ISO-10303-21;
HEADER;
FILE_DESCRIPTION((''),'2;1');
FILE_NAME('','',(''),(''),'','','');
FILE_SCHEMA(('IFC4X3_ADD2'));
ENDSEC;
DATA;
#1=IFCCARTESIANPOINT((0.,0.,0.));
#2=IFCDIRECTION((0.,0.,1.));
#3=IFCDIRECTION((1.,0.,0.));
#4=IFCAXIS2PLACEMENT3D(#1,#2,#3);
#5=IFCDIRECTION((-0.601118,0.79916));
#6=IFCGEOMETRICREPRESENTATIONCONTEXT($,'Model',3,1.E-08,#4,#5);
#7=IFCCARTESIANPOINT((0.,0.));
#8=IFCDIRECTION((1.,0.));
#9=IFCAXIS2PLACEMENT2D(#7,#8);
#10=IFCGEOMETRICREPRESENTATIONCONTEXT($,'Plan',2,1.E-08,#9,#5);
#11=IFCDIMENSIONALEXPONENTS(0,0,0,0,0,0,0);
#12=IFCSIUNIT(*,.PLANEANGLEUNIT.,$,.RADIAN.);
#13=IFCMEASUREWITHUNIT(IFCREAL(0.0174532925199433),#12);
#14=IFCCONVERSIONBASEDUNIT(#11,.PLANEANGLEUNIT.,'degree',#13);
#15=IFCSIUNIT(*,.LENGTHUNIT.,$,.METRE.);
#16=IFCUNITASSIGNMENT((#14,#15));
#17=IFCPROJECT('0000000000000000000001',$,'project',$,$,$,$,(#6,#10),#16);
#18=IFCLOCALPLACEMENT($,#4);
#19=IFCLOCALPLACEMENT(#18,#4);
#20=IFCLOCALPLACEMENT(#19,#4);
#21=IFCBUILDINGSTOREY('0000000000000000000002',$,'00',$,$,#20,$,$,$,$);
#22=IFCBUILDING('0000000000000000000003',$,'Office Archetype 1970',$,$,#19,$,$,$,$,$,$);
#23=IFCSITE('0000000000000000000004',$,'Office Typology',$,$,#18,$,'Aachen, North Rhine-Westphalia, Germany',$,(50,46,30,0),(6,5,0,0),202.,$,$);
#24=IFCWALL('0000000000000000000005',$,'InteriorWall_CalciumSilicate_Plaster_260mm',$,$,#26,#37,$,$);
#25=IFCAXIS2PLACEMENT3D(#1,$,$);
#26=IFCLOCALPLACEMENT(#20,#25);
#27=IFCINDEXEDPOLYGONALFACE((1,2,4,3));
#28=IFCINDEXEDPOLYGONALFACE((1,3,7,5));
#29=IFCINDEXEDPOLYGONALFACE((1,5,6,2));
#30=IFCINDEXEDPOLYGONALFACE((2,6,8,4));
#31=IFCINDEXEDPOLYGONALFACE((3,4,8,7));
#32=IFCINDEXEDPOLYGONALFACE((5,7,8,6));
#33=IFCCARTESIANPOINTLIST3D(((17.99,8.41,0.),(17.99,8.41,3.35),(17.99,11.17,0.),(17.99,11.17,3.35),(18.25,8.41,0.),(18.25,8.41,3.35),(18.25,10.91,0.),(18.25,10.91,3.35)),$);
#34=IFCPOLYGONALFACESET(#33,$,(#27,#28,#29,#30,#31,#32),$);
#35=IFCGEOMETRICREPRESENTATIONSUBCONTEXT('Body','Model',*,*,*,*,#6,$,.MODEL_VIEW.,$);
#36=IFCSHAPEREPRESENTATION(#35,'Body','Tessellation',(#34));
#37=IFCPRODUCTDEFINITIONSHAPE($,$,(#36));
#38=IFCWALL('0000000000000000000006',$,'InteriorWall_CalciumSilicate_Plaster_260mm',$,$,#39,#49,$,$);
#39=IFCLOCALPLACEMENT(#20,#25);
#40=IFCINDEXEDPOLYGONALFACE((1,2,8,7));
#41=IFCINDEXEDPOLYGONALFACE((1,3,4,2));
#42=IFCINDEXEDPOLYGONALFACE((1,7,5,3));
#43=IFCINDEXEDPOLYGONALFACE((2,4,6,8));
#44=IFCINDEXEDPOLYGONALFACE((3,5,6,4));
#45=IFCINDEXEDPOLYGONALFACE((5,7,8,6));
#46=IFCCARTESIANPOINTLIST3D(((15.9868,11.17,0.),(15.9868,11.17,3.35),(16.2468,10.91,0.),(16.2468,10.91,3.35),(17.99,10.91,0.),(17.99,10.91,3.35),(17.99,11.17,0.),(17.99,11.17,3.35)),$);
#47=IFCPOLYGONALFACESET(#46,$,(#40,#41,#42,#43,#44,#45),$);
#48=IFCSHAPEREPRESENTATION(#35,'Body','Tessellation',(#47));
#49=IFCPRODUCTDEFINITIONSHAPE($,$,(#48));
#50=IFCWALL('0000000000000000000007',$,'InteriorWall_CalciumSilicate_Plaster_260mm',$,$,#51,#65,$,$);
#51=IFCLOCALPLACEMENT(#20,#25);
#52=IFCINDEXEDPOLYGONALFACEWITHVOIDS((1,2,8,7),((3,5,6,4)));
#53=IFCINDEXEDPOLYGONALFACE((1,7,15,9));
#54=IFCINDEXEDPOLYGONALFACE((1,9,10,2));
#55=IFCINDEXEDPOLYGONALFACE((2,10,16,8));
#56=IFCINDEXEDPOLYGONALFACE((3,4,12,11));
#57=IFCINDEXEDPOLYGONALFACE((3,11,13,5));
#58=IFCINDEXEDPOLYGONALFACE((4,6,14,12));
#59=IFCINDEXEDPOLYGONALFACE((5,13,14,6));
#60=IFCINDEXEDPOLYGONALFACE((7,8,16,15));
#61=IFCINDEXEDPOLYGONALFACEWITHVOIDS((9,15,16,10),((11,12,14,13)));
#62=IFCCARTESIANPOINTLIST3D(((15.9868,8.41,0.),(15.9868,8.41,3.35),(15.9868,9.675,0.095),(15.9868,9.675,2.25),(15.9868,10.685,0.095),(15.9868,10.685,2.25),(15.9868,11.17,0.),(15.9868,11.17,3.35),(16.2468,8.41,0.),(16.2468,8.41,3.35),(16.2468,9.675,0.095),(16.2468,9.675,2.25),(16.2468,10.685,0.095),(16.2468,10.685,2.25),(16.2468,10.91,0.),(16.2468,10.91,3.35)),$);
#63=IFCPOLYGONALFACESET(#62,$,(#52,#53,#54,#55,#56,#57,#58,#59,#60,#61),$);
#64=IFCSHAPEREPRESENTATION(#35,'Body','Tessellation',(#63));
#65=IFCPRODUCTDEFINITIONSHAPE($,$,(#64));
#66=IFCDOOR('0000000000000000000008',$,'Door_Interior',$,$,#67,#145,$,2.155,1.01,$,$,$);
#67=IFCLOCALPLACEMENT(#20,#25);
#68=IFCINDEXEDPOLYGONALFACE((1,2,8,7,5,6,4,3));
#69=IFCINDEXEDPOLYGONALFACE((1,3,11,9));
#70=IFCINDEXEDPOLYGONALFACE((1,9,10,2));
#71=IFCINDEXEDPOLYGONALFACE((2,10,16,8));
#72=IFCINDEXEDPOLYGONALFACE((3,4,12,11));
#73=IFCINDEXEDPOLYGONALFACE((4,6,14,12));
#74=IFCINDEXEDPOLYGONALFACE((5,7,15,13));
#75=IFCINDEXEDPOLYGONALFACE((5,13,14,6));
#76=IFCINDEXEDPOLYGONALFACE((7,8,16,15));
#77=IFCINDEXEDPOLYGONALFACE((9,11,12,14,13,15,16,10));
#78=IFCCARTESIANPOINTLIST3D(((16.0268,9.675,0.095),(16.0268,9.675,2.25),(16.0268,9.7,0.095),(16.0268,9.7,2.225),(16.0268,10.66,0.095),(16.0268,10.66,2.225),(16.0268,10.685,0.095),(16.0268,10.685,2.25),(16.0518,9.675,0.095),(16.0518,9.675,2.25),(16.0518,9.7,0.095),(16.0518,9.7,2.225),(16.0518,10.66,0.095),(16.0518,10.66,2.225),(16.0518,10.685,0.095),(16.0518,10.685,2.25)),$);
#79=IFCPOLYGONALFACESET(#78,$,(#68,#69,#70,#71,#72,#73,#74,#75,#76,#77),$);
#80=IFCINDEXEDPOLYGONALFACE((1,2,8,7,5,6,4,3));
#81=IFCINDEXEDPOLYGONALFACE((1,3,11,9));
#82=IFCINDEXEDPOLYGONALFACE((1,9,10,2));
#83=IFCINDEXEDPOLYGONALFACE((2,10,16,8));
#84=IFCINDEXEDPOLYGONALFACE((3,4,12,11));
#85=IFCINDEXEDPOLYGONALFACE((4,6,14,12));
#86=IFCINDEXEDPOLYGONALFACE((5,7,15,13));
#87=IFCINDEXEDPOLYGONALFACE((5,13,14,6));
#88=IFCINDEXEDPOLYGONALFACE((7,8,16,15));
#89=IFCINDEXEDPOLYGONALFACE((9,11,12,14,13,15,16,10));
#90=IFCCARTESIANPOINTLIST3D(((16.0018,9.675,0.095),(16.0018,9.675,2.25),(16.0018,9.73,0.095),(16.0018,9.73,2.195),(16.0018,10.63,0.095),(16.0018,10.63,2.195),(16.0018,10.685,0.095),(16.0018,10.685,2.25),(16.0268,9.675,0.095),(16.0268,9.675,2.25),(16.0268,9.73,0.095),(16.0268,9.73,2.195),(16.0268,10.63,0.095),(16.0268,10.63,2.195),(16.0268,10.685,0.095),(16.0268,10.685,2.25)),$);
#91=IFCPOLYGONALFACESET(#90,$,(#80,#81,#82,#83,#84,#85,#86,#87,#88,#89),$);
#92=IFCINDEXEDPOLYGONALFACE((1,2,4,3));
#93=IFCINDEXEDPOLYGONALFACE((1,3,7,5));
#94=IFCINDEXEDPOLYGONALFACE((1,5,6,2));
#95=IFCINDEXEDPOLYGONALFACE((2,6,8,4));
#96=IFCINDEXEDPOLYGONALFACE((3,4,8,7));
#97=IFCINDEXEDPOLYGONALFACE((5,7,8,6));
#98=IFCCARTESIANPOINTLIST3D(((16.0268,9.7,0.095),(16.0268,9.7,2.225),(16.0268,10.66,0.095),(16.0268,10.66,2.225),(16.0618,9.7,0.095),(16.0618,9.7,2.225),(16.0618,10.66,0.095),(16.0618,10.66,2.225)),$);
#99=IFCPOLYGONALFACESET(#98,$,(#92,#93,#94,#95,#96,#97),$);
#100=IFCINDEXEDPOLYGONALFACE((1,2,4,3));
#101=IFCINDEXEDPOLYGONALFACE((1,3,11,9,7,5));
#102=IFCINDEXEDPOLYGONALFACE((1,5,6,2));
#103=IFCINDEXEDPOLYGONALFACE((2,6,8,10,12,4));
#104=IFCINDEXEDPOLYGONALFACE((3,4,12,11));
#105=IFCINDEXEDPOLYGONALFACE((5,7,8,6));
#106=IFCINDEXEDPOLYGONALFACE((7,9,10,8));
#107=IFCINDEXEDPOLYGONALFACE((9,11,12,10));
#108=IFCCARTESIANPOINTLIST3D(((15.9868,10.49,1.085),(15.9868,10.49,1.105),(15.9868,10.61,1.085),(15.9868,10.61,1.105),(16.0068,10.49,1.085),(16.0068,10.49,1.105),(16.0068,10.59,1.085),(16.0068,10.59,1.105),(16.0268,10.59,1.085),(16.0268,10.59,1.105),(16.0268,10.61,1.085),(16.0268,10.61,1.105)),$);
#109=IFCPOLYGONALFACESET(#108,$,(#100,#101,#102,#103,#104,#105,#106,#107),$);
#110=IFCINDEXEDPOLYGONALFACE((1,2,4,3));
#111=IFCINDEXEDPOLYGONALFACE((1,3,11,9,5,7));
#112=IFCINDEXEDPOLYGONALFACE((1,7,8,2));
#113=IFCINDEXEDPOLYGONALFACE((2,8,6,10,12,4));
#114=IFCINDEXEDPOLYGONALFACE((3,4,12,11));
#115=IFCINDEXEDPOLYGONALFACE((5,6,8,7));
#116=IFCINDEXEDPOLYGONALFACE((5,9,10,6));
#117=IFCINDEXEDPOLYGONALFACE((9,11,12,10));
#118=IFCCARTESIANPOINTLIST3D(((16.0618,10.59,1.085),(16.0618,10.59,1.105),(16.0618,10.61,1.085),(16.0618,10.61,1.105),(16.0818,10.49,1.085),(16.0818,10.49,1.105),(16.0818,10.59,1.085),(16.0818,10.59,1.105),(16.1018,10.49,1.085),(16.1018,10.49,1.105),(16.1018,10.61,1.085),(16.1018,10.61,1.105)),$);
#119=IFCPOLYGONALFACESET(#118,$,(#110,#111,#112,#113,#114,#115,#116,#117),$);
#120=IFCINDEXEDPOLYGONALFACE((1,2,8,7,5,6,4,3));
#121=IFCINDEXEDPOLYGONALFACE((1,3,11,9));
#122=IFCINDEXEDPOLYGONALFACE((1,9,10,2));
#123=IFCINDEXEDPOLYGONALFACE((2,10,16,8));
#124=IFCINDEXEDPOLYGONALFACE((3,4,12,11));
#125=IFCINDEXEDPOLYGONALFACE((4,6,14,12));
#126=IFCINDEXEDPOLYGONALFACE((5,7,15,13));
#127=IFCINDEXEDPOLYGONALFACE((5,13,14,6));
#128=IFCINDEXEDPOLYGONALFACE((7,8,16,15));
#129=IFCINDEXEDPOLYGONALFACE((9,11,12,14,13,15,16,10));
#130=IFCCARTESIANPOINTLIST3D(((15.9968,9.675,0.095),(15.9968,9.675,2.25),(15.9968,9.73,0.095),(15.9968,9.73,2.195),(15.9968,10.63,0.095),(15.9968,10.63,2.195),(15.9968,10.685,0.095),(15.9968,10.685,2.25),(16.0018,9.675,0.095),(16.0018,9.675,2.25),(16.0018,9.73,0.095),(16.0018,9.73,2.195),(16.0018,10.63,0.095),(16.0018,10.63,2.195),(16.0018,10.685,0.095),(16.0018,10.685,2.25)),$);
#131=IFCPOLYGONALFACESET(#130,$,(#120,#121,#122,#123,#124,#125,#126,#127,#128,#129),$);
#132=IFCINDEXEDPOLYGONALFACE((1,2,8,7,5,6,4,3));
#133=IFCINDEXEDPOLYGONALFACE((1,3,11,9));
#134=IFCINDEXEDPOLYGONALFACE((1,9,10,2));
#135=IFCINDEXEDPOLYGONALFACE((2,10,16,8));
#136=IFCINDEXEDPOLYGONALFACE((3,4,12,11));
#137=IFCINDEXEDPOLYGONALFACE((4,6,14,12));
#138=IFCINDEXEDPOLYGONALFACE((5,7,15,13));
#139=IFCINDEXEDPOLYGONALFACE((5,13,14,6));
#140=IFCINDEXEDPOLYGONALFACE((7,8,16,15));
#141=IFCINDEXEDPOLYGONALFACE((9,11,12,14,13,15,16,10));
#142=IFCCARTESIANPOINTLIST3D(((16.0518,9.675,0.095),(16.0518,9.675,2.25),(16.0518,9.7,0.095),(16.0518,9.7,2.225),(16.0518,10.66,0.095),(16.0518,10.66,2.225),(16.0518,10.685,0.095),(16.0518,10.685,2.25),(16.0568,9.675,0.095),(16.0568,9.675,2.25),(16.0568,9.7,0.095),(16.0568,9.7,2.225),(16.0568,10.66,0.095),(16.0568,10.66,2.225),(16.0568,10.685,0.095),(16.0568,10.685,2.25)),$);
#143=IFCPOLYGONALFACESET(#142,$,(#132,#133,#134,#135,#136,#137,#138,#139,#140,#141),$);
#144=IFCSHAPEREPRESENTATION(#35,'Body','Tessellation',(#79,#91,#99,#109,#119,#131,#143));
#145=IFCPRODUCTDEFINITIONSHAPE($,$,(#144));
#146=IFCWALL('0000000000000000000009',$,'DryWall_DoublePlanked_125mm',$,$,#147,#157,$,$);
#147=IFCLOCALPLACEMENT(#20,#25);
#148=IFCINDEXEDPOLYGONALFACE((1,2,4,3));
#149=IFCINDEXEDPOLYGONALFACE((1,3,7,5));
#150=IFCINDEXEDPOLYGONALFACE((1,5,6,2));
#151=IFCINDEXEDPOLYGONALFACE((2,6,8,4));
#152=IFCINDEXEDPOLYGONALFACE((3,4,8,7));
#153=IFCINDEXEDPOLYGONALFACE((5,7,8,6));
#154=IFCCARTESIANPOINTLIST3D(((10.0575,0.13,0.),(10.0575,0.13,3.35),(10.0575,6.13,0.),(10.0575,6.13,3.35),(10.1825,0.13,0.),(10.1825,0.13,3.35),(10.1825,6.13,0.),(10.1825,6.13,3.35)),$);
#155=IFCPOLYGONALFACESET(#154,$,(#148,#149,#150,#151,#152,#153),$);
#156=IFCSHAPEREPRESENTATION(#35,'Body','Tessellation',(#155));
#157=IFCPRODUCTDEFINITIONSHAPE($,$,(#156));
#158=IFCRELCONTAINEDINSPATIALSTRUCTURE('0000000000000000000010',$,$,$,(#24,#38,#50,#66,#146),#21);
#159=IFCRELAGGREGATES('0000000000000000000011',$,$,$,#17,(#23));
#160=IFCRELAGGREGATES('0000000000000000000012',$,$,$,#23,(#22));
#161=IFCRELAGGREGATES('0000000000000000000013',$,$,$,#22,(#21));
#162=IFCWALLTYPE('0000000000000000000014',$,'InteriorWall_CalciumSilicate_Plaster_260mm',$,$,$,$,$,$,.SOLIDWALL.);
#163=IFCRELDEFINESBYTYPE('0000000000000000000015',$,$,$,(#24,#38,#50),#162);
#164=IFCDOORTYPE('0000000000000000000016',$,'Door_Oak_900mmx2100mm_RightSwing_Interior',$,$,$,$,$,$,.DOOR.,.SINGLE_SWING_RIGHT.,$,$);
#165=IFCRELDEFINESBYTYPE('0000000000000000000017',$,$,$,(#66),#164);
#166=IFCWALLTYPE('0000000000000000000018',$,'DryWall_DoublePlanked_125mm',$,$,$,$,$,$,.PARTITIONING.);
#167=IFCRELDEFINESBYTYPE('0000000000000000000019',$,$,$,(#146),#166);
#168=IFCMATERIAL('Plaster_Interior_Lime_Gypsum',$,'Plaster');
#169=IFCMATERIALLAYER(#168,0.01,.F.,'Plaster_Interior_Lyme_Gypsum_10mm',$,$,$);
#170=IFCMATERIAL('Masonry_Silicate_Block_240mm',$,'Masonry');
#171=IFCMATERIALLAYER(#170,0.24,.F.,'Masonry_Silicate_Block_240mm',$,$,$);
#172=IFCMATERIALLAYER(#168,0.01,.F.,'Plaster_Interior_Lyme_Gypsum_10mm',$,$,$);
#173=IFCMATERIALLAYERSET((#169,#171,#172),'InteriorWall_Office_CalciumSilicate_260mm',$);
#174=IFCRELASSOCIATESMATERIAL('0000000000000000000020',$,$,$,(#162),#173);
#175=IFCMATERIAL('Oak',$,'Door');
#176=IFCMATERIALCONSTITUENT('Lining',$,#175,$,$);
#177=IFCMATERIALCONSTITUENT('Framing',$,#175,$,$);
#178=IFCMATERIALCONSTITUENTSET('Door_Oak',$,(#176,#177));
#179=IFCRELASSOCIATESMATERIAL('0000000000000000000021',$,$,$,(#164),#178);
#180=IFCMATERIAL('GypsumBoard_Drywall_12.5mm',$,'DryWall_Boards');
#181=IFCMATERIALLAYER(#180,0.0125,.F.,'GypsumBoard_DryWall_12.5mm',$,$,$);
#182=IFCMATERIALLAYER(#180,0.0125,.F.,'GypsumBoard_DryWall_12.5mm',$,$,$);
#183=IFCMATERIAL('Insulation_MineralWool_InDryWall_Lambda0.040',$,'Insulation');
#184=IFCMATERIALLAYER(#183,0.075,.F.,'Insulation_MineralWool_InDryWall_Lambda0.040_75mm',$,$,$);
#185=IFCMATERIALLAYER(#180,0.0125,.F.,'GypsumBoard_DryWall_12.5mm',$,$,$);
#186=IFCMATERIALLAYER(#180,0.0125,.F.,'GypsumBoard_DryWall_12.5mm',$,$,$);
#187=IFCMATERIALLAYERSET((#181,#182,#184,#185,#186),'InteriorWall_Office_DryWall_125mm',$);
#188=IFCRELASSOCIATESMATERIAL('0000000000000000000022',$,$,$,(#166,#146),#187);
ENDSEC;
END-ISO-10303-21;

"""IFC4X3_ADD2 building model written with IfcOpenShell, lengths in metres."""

from ifc_helpers import new_model, entity, si_unit, converted_unit, direction, frame, origin_with_axes, origin_2d_with_axis, place, context, subcontext, project, spatial, line, indexed_curve, outline, extrude, source, transform, mapped, material, layer, layer_set, layer_usage, constituent, constituent_set, type_object, type_shapes, element, fill, save


model = new_model("IFC4X3_ADD2")

# Units and contexts
model_context = context("Model", 3, precision=1e-08, world=origin_with_axes(), true_north=direction((-0.601118, 0.79916)))
plan_context = context("Plan", 2, precision=1e-08, world=origin_2d_with_axis(), true_north=direction((-0.601118, 0.79916)))
body_context = subcontext(model_context, "Body", "Model", "MODEL_VIEW")
ifc_project = project(units=[converted_unit("PLANEANGLEUNIT", "degree", entity("IfcReal", 0.0174532925199433), si_unit("PLANEANGLEUNIT", "RADIAN"), dimensions=[0, 0, 0, 0, 0, 0, 0]), si_unit("LENGTHUNIT", "METRE")], contexts=[model_context, plan_context])

# Site, building, storey
site_placement = place(None, origin_with_axes())
site = spatial("IfcSite", under=ifc_project, at=site_placement, Name="Office Typology", LongName="Aachen, North Rhine-Westphalia, Germany", RefLatitude=(50, 46, 30, 0), RefLongitude=(6, 5, 0, 0), RefElevation=202.0)
building_placement = place(site_placement, origin_with_axes())
building = spatial("IfcBuilding", under=site, at=building_placement, Name="Office Archetype 1970")
storey_placement = place(building_placement, origin_with_axes())
storey = spatial("IfcBuildingStorey", under=building, at=storey_placement, Name="00")

# Walls
ifc_material_1 = material(Name="Plaster_Interior_Lime_Gypsum", Category="Plaster")
ifc_layer_1 = layer(ifc_material_1, 0.01, ventilated=False, Name="Plaster_Interior_Lyme_Gypsum_10mm")
ifc_material_2 = material(Name="Masonry_Silicate_Block_240mm", Category="Masonry")
ifc_layer_2 = layer(ifc_material_2, 0.24, ventilated=False, Name="Masonry_Silicate_Block_240mm")
ifc_layer_3 = layer(ifc_material_1, 0.01, ventilated=False, Name="Plaster_Interior_Lyme_Gypsum_10mm")
ifc_layer_set_1 = layer_set([ifc_layer_1, ifc_layer_2, ifc_layer_3], Name="InteriorWall_Office_CalciumSilicate_260mm")
wall_type_1 = type_object("IfcWallType", Name="InteriorWall_CalciumSilicate_Plaster_260mm", PredefinedType="SOLIDWALL", material=ifc_layer_set_1)
wall_1_placement = place(storey_placement, frame((17.99, 11.17, 0.0), z_axis=(0.0, 0.0, 1.0), x_axis=(0.0, -1.0, 0.0)))
element("IfcWall", 1, at=wall_1_placement, inside=storey, type_object=wall_type_1, Name="InteriorWall_CalciumSilicate_Plaster_260mm", context=body_context, shape_type="SweptSolid", body=[
    extrude(outline(indexed_curve([(0.0, 0.0), (0.26, 0.26), (2.76, 0.26), (2.76, 0.0)], segments=[line(1, 2, 3, 4, 1)])), origin_with_axes(), (0.0, 0.0, 1.0), 3.35),
])
wall_2_placement = place(storey_placement, frame((17.99, 11.17, 0.0), z_axis=(0.0, 0.0, 1.0), x_axis=(-1.0, 0.0, 0.0)))
element("IfcWall", 2, at=wall_2_placement, inside=storey, type_object=wall_type_1, Name="InteriorWall_CalciumSilicate_Plaster_260mm", context=body_context, shape_type="SweptSolid", body=[
    extrude(outline(indexed_curve([(0.0, 0.0), (0.0, 0.26), (1.7432, 0.26), (2.0032, 0.0)], segments=[line(1, 2, 3, 4, 1)])), origin_with_axes(), (0.0, 0.0, 1.0), 3.35),
])

# Wall, opening, door
wall_3_placement = place(storey_placement, frame((15.9868, 11.17, 0.0), z_axis=(0.0, 0.0, 1.0), x_axis=(0.0, -1.0, 0.0)))
wall_3 = element("IfcWall", 3, at=wall_3_placement, inside=storey, type_object=wall_type_1, Name="InteriorWall_CalciumSilicate_Plaster_260mm", context=body_context, shape_type="SweptSolid", body=[
    extrude(outline(indexed_curve([(0.0, 0.0), (0.26, 0.26), (2.76, 0.26), (2.76, 0.0)], segments=[line(1, 2, 3, 4, 1)])), origin_with_axes(), (0.0, 0.0, 1.0), 3.35),
])
shared_shape_1 = source(origin_with_axes(), body_context, "Body", "SweptSolid", [
    extrude(outline(indexed_curve([(0.0, 0.0), (1.01, 0.0), (1.01, 2.155), (0.0, 2.155), (0.0, 0.0)])), frame((0.0, -0.015, 0.0), z_axis=(0.0, -1.0, 0.0), x_axis=(1.0, 0.0, 0.0)), (0.0, 0.0, -1.0), 0.26),
])
opening_placement = place(wall_3_placement, frame((0.485, 0.015, 0.095), z_axis=(0.0, 0.0, 1.0), x_axis=(1.0, 0.0, 0.0)))
opening = element("IfcOpeningElement", 4, at=opening_placement, cuts=wall_3, PredefinedType="OPENING", context=body_context, shape_type="MappedRepresentation", body=[
    mapped(shared_shape_1, transform((0.0, 0.0, 0.0), x_axis=(1.0, 0.0, 0.0), y_axis=(0.0, 1.0, 0.0), z_axis=(0.0, 0.0, 1.0), scale=1.0)),
])
ifc_material_3 = material(Name="Oak", Category="Door")
ifc_constituent_1 = constituent(ifc_material_3, Name="Lining")
ifc_constituent_2 = constituent(ifc_material_3, Name="Framing")
ifc_constituent_set = constituent_set(constituents=[ifc_constituent_1, ifc_constituent_2], Name="Door_Oak")
door_type = type_object("IfcDoorType", Name="Door_Oak_900mmx2100mm_RightSwing_Interior", OperationType="SINGLE_SWING_RIGHT", PredefinedType="DOOR", material=ifc_constituent_set)
shared_shape_2 = source(origin_with_axes(), body_context, "Body", "SweptSolid", [
    extrude(outline(indexed_curve([(0.0, 0.0), (0.0, 2.155), (1.01, 2.155), (1.01, 0.0), (0.985, 0.0), (0.985, 2.13), (0.025, 2.13), (0.025, 0.0)], segments=[line(1, 2, 3, 4, 5, 6, 7, 8, 1)])), frame((0.0, 0.025, 0.0), z_axis=(0.0, -1.0, 0.0), x_axis=(1.0, 0.0, 0.0)), (0.0, 0.0, -1.0), 0.025),
    extrude(outline(indexed_curve([(0.0, 0.0), (0.0, 2.155), (1.01, 2.155), (1.01, 0.0), (0.955, 0.0), (0.955, 2.1), (0.055, 2.1), (0.055, 0.0)], segments=[line(1, 2, 3, 4, 5, 6, 7, 8, 1)])), frame((0.0, 0.0, 0.0), z_axis=(0.0, -1.0, 0.0), x_axis=(1.0, 0.0, 0.0)), (0.0, 0.0, -1.0), 0.025),
    extrude(outline(indexed_curve([(0.0, 0.0), (0.96, 0.0), (0.96, 0.035), (0.0, 0.035)], segments=[line(1, 2, 3, 4, 1)])), frame((0.025, 0.025, 0.0), z_axis=(0.0, 0.0, 1.0), x_axis=(1.0, 0.0, 0.0)), (0.0, 0.0, 1.0), 2.13),
    extrude(outline(indexed_curve([(0.0, 0.0), (0.0, -0.04), (0.12, -0.04), (0.12, -0.02), (0.02, -0.02), (0.02, 0.0)], segments=[line(1, 2, 3, 4, 5, 6, 1)])), frame((0.075, 0.025, 0.99), z_axis=(0.0, 0.0, 1.0), x_axis=(1.0, 0.0, 0.0)), (0.0, 0.0, 1.0), 0.02),
    extrude(outline(indexed_curve([(0.0, 0.0), (0.0, 0.04), (0.12, 0.04), (0.12, 0.02), (0.02, 0.02), (0.02, 0.0)], segments=[line(1, 2, 3, 4, 5, 6, 1)])), frame((0.075, 0.06, 0.99), z_axis=(0.0, 0.0, 1.0), x_axis=(1.0, 0.0, 0.0)), (0.0, 0.0, 1.0), 0.02),
    extrude(outline(indexed_curve([(0.0, 0.0), (0.0, 2.155), (1.01, 2.155), (1.01, 0.0), (0.955, 0.0), (0.955, 2.1), (0.055, 2.1), (0.055, 0.0)], segments=[line(1, 2, 3, 4, 5, 6, 7, 8, 1)])), frame((0.0, -0.005, 0.0), z_axis=(0.0, -1.0, 0.0), x_axis=(1.0, 0.0, 0.0)), (0.0, 0.0, -1.0), 0.005),
    extrude(outline(indexed_curve([(0.0, 0.0), (0.0, 2.155), (1.01, 2.155), (1.01, 0.0), (0.985, 0.0), (0.985, 2.13), (0.025, 2.13), (0.025, 0.0)], segments=[line(1, 2, 3, 4, 5, 6, 7, 8, 1)])), frame((0.0, 0.05, 0.0), z_axis=(0.0, -1.0, 0.0), x_axis=(1.0, 0.0, 0.0)), (0.0, 0.0, -1.0), 0.005),
])
type_shapes(door_type, [shared_shape_2])
door_placement = place(opening_placement, origin_with_axes())
door = element("IfcDoor", 5, at=door_placement, inside=storey, type_object=door_type, Name="Door_Interior", OverallHeight=2.155, OverallWidth=1.01, context=body_context, shape_type="MappedRepresentation", body=[
    mapped(shared_shape_2, transform((0.0, 0.0, 0.0), x_axis=(1.0, 0.0, 0.0), y_axis=(0.0, 1.0, 0.0), z_axis=(0.0, 0.0, 1.0), scale=1.0)),
])
fill(opening, door)

# Wall
ifc_material_4 = material(Name="GypsumBoard_Drywall_12.5mm", Category="DryWall_Boards")
ifc_layer_4 = layer(ifc_material_4, 0.0125, ventilated=False, Name="GypsumBoard_DryWall_12.5mm")
ifc_layer_5 = layer(ifc_material_4, 0.0125, ventilated=False, Name="GypsumBoard_DryWall_12.5mm")
ifc_material_5 = material(Name="Insulation_MineralWool_InDryWall_Lambda0.040", Category="Insulation")
ifc_layer_6 = layer(ifc_material_5, 0.075, ventilated=False, Name="Insulation_MineralWool_InDryWall_Lambda0.040_75mm")
ifc_layer_7 = layer(ifc_material_4, 0.0125, ventilated=False, Name="GypsumBoard_DryWall_12.5mm")
ifc_layer_8 = layer(ifc_material_4, 0.0125, ventilated=False, Name="GypsumBoard_DryWall_12.5mm")
ifc_layer_set_2 = layer_set([ifc_layer_4, ifc_layer_5, ifc_layer_6, ifc_layer_7, ifc_layer_8], Name="InteriorWall_Office_DryWall_125mm")
wall_type_2 = type_object("IfcWallType", Name="DryWall_DoublePlanked_125mm", PredefinedType="PARTITIONING", material=ifc_layer_set_2)
ifc_layer_usage_1 = layer_usage(ifc_layer_set_2, "AXIS2", "POSITIVE", 0.0)
wall_4_placement = place(storey_placement, frame((10.0575, 6.13, 0.0), z_axis=(0.0, 0.0, 1.0), x_axis=(0.0, -1.0, 0.0)))
element("IfcWall", 6, at=wall_4_placement, inside=storey, type_object=wall_type_2, material=ifc_layer_usage_1, Name="DryWall_DoublePlanked_125mm", context=body_context, shape_type="SweptSolid", body=[
    extrude(outline(indexed_curve([(0.0, 0.0), (0.0, 0.125), (6.0, 0.125), (6.0, 0.0)], segments=[line(1, 2, 3, 4, 1)])), origin_with_axes(), (0.0, 0.0, 1.0), 3.35),
])

save(model, "model.ifc")
